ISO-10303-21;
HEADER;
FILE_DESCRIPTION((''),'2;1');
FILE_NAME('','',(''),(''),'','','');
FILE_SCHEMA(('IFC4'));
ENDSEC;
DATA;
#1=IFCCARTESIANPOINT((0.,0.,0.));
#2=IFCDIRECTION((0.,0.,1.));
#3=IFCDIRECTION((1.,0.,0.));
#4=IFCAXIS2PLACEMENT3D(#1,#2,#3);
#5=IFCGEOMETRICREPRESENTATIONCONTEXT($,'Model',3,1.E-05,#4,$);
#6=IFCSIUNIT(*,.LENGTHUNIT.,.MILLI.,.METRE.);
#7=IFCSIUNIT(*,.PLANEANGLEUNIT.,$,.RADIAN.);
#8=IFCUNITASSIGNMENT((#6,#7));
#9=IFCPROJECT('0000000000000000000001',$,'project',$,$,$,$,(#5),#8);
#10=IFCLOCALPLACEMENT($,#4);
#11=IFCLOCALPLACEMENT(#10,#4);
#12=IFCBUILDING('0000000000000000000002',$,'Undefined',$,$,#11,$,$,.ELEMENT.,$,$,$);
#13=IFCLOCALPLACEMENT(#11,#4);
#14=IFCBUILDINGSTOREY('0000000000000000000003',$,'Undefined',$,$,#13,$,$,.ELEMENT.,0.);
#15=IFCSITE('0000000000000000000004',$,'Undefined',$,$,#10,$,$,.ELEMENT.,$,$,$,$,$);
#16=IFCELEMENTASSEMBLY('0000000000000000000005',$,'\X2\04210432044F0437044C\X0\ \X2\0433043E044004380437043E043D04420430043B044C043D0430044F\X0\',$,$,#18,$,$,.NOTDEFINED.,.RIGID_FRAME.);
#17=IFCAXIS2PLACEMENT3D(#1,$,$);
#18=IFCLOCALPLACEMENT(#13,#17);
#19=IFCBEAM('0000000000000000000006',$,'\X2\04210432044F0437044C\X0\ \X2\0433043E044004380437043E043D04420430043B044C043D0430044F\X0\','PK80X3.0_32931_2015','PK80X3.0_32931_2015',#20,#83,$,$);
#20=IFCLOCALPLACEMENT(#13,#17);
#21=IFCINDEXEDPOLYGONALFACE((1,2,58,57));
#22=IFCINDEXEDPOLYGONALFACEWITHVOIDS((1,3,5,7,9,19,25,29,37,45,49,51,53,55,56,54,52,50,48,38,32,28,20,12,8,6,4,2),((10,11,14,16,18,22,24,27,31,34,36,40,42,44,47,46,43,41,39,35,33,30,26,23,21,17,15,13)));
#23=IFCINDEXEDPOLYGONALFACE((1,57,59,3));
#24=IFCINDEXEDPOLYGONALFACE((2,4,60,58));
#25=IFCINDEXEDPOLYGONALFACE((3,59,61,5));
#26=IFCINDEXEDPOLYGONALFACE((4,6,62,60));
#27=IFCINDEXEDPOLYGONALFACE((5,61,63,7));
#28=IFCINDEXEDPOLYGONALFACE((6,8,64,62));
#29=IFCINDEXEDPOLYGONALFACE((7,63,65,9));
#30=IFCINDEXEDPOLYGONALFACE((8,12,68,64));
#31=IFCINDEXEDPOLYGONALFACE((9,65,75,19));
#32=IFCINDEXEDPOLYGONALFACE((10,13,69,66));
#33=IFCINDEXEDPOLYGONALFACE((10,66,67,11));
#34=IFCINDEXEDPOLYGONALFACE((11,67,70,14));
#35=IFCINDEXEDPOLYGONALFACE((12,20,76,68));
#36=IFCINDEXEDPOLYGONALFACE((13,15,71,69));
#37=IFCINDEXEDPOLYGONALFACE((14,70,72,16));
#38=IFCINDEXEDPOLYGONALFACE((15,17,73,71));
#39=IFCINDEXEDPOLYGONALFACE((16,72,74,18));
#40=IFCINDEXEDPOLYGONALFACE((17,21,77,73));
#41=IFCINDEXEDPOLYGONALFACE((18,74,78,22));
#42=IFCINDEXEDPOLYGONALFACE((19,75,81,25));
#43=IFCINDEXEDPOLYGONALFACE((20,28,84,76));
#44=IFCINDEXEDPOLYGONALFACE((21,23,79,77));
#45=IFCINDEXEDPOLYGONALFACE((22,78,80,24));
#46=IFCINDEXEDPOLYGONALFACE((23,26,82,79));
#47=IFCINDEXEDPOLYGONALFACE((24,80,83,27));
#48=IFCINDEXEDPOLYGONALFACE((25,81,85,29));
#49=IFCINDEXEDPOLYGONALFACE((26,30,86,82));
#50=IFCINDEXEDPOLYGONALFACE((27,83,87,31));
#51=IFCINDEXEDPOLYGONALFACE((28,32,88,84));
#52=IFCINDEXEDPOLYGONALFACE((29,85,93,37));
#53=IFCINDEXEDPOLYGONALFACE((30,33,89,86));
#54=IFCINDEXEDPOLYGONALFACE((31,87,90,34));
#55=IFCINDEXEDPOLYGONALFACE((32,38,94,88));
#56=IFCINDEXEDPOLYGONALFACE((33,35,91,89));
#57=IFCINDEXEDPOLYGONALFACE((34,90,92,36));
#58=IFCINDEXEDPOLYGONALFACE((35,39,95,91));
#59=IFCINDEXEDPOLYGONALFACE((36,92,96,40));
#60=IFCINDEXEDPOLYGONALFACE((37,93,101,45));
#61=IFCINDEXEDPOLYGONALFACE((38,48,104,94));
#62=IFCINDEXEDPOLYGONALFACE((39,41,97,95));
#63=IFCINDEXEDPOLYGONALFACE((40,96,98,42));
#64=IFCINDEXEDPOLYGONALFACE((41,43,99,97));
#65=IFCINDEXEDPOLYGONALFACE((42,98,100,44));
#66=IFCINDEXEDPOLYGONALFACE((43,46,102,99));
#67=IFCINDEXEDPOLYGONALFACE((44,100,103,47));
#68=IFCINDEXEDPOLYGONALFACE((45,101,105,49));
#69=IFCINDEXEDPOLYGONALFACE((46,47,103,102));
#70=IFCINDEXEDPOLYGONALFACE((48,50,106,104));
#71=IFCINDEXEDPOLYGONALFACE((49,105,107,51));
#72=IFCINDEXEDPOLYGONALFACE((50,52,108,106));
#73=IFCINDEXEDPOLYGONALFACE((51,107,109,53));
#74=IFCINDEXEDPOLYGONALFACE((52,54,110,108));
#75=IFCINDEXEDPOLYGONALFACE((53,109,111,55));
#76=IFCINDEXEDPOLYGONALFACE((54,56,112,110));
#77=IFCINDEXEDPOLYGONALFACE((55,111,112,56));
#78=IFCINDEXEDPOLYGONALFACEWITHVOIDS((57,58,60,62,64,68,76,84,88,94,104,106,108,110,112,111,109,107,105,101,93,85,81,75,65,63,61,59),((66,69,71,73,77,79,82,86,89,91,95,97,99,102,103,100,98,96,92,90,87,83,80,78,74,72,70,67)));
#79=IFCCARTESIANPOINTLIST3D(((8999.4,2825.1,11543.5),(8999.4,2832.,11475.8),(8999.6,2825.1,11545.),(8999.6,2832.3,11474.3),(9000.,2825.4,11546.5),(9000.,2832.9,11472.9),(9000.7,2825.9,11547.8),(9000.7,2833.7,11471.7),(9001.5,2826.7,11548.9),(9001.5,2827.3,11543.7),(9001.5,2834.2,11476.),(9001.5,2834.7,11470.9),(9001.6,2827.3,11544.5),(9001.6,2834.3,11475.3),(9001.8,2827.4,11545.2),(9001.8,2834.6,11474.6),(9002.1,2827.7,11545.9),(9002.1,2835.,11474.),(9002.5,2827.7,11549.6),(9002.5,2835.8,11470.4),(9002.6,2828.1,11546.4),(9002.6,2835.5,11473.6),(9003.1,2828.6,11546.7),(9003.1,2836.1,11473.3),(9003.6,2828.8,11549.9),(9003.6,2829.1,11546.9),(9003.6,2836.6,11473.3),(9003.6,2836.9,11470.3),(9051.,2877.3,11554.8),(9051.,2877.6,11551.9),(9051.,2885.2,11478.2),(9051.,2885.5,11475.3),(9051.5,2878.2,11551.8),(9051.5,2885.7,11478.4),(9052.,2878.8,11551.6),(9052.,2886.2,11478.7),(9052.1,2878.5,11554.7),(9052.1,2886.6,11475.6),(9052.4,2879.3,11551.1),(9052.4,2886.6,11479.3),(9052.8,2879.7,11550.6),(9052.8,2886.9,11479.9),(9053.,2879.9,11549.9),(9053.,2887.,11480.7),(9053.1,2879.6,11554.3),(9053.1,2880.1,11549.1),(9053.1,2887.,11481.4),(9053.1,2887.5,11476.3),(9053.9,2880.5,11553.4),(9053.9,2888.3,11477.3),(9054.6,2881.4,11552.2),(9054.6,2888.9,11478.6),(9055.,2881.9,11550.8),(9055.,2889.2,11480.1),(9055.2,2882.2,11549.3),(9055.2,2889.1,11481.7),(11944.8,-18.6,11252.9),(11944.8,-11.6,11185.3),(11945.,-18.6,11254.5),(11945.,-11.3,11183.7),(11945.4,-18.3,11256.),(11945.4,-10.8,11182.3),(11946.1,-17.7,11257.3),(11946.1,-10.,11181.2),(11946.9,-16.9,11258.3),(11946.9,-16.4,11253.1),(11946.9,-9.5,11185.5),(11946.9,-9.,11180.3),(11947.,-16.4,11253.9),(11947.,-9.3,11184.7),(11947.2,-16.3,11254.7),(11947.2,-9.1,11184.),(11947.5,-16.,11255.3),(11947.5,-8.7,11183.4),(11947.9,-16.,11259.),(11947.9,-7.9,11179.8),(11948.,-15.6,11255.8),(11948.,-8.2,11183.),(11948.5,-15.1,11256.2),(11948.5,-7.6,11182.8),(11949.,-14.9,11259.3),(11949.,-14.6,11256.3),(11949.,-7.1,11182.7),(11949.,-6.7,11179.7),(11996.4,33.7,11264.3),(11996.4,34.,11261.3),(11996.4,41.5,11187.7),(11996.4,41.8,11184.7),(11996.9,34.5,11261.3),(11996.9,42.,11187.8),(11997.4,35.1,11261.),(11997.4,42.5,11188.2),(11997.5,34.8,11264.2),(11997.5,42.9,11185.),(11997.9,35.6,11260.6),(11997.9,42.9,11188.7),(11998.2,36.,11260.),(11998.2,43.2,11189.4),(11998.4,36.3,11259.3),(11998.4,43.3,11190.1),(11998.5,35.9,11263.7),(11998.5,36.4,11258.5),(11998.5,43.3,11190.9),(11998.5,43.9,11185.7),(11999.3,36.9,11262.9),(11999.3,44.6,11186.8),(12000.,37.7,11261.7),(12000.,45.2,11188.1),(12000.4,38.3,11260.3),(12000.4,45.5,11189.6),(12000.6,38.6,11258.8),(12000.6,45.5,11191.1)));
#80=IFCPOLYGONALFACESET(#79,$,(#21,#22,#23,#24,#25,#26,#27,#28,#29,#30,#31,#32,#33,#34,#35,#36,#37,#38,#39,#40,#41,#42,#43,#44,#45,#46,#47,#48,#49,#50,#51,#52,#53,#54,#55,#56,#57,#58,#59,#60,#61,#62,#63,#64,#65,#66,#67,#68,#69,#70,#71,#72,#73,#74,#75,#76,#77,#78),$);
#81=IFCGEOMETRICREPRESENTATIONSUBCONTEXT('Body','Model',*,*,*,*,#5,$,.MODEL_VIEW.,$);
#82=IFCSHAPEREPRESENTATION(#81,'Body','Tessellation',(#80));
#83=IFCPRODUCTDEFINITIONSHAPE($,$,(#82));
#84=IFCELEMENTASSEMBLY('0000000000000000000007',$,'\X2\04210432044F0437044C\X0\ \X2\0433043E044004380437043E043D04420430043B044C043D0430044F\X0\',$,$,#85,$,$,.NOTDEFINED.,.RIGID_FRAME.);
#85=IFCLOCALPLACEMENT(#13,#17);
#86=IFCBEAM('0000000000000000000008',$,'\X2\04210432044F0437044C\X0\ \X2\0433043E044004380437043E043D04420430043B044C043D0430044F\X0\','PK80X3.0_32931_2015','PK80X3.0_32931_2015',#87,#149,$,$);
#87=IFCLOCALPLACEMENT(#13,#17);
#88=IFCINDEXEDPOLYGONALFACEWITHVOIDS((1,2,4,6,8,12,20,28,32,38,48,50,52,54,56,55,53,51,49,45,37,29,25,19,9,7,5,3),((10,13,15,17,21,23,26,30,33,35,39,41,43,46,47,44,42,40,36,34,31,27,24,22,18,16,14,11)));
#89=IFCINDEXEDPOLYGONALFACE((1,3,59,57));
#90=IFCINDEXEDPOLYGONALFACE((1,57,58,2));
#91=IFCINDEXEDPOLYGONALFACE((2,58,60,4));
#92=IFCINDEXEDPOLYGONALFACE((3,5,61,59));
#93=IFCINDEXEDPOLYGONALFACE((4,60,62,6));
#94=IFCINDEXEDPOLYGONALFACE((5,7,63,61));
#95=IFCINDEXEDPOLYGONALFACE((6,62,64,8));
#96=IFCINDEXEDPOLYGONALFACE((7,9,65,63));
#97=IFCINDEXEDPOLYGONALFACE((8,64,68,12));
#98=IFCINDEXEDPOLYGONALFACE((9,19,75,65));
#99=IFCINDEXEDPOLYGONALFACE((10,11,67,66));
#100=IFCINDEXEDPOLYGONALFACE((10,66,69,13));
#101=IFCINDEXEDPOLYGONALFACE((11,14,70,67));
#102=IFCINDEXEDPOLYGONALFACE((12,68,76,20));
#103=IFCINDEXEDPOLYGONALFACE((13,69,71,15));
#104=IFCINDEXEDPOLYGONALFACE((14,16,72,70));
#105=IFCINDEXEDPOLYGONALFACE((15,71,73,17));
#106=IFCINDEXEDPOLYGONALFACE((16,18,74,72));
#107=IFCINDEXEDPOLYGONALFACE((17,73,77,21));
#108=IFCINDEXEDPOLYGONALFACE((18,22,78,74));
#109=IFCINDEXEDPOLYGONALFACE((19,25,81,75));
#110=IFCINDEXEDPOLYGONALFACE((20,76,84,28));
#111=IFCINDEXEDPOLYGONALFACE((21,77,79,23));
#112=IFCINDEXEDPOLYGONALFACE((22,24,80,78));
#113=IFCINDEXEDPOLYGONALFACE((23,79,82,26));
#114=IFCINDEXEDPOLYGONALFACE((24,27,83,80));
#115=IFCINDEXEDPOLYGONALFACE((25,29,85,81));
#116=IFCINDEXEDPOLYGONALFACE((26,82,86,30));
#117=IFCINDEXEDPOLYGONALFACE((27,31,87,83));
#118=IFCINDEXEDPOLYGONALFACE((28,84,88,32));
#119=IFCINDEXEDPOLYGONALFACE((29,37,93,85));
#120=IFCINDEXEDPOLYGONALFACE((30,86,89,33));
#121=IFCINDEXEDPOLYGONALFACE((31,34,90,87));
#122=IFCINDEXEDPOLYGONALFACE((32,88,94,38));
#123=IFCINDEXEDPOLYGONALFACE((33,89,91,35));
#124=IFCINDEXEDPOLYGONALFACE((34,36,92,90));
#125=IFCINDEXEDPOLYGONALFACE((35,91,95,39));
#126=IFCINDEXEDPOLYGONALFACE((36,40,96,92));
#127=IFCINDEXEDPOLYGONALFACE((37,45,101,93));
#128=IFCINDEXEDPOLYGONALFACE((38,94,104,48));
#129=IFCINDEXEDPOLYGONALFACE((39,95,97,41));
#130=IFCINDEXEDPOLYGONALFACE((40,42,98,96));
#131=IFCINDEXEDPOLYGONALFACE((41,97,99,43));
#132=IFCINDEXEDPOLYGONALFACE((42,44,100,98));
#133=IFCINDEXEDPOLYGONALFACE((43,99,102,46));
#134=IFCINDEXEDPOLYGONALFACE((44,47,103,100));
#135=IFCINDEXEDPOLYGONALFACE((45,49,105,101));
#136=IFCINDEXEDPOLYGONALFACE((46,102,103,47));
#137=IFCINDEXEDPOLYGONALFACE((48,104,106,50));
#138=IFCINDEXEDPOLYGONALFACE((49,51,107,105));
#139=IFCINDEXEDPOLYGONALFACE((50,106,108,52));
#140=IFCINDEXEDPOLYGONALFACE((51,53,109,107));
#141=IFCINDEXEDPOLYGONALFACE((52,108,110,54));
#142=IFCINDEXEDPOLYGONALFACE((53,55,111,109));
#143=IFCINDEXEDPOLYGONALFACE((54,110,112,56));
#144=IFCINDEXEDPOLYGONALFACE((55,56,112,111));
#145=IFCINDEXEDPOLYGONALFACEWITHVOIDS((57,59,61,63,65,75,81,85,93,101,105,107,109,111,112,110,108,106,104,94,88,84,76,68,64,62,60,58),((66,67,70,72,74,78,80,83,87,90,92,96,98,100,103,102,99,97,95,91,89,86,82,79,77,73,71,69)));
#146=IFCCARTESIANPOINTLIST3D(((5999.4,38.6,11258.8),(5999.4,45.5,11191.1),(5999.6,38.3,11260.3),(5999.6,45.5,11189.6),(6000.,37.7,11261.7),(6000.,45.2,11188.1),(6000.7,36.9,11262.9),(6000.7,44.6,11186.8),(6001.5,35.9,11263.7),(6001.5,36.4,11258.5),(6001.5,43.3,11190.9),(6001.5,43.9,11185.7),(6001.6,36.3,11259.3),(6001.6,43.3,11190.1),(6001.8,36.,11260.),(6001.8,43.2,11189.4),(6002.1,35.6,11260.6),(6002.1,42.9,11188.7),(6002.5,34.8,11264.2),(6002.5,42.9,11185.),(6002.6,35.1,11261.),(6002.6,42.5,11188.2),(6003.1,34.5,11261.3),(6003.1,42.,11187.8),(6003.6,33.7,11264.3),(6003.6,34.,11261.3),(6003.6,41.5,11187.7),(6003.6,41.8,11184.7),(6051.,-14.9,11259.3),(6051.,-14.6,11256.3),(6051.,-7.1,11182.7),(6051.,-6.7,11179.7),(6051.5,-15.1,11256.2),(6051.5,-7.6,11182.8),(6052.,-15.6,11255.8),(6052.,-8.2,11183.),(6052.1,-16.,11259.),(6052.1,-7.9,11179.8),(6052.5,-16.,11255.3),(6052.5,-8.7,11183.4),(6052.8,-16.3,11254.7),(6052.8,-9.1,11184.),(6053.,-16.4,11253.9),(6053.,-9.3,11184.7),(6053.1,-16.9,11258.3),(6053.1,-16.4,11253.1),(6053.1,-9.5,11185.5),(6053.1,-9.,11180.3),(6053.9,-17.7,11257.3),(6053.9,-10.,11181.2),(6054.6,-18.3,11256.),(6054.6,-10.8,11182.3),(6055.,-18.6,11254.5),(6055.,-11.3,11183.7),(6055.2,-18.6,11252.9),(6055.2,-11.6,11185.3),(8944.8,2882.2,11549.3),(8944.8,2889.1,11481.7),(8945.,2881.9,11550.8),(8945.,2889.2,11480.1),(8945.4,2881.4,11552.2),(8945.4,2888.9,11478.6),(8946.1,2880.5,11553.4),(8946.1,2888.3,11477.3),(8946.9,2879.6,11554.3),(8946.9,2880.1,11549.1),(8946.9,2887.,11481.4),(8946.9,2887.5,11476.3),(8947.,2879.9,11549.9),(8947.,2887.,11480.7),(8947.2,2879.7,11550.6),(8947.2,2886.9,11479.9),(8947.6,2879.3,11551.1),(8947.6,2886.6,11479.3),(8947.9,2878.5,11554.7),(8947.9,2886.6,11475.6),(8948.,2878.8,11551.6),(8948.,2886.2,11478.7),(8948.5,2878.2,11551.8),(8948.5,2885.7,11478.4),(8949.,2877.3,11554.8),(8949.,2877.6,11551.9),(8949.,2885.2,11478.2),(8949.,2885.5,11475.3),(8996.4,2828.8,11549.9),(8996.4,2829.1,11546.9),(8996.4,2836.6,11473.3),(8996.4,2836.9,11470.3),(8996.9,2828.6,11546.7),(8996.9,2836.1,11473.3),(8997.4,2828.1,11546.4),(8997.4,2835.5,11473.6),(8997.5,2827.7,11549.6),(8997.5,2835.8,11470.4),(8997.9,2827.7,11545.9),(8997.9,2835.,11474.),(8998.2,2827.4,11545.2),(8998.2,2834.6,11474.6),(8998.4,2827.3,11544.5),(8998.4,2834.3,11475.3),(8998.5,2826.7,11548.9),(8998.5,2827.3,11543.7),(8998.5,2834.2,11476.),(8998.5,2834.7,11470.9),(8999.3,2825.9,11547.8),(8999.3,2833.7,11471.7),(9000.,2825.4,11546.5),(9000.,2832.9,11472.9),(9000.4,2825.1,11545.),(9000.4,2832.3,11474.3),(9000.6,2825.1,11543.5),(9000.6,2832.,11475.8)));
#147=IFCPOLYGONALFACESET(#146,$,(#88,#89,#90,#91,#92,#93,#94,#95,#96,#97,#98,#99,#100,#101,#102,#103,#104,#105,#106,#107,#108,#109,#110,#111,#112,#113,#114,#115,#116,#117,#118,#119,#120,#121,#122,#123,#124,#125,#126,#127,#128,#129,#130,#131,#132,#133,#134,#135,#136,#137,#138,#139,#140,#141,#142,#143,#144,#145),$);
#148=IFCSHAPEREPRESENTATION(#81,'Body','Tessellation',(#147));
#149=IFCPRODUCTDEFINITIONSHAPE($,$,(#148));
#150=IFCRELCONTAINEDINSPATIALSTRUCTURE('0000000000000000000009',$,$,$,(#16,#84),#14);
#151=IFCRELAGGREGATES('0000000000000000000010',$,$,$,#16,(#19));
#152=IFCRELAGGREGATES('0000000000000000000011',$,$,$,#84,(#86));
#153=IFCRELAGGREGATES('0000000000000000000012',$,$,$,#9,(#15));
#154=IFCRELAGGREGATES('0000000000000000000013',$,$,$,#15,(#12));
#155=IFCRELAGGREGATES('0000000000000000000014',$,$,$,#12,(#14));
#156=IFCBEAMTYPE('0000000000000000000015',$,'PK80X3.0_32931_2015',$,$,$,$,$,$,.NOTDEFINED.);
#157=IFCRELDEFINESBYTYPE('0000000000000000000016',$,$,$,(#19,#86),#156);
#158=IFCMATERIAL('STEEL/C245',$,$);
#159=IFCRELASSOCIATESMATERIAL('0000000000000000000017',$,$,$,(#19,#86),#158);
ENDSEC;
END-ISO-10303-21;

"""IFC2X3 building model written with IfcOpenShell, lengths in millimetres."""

from ifc_helpers import new_model, si_unit, frame, origin_with_axes, origin_2d_with_axis, place, context, subcontext, project, spatial, hollow_rectangle, extrude, material, type_object, element, aggregate, save


model = new_model("IFC2X3")

# Units and contexts
model_context = context("Model", 3, precision=1e-05, world=origin_with_axes())
body_context = subcontext(model_context, "Body", "Model", "MODEL_VIEW")
ifc_project = project(units=[si_unit("LENGTHUNIT", "METRE", prefix="MILLI"), si_unit("PLANEANGLEUNIT", "RADIAN")], contexts=[model_context])

# Site, building, storey
site_placement = place(None, origin_with_axes())
site = spatial("IfcSite", under=ifc_project, at=site_placement, Name="Undefined", CompositionType="ELEMENT")
building_placement = place(site_placement, origin_with_axes())
building = spatial("IfcBuilding", under=site, at=building_placement, Name="Undefined", CompositionType="ELEMENT")
storey_placement = place(building_placement, origin_with_axes())
storey = spatial("IfcBuildingStorey", under=building, at=storey_placement, Name="Undefined", CompositionType="ELEMENT", Elevation=0.0)

# Element assemblies, beams
ifc_material_1 = material(Name="STEEL/C245")
assembly_1_placement = place(storey_placement, origin_with_axes())
assembly_1 = element("IfcElementAssembly", 1, at=assembly_1_placement, inside=storey, Name="Связь горизонтальная", AssemblyPlace="NOTDEFINED", PredefinedType="RIGID_FRAME")
beam_type_1 = type_object("IfcBeamType", Name="PK80X3.0_32931_2015", PredefinedType="NOTDEFINED")
beam_1_placement = place(assembly_1_placement, frame((11972.7, 13.5, 11222.0), z_axis=(0.0, -0.101645, 0.994821), x_axis=(-0.717617, 0.69283, 0.070789)))
beam_1 = element("IfcBeam", 2, at=beam_1_placement, type_object=beam_type_1, material=ifc_material_1, Name="Связь горизонтальная", Description="PK80X3.0_32931_2015", ObjectType="PK80X3.0_32931_2015", context=body_context, shape_type="SweptSolid", body=[
    extrude(hollow_rectangle(XDim=80.0, YDim=80.0, WallThickness=3.0, InnerFilletRadius=3.0, OuterFilletRadius=6.0, at=origin_2d_with_axis()), frame((4104.4, 0.0, 0.0), z_axis=(-1.0, 0.0, 0.0), x_axis=(0.0, -1.0, 0.0)), (0.0, 0.0, 1.0), 4104.4),
])
aggregate(assembly_1, [beam_1])
assembly_2_placement = place(storey_placement, origin_with_axes())
assembly_2 = element("IfcElementAssembly", 3, at=assembly_2_placement, inside=storey, Name="Связь горизонтальная", AssemblyPlace="NOTDEFINED", PredefinedType="RIGID_FRAME")
beam_2_placement = place(assembly_2_placement, frame((6027.3, 13.5, 11222.0), z_axis=(0.0, -0.101645, 0.994821), x_axis=(0.717617, 0.69283, 0.070789)))
beam_2 = element("IfcBeam", 4, at=beam_2_placement, type_object=beam_type_1, material=ifc_material_1, Name="Связь горизонтальная", Description="PK80X3.0_32931_2015", ObjectType="PK80X3.0_32931_2015", context=body_context, shape_type="SweptSolid", body=[
    extrude(hollow_rectangle(XDim=80.0, YDim=80.0, WallThickness=3.0, InnerFilletRadius=3.0, OuterFilletRadius=6.0, at=origin_2d_with_axis()), frame((4104.4, 0.0, 0.0), z_axis=(-1.0, 0.0, 0.0), x_axis=(0.0, -1.0, 0.0)), (0.0, 0.0, 1.0), 4104.4),
])
aggregate(assembly_2, [beam_2])

save(model, "model.ifc")
